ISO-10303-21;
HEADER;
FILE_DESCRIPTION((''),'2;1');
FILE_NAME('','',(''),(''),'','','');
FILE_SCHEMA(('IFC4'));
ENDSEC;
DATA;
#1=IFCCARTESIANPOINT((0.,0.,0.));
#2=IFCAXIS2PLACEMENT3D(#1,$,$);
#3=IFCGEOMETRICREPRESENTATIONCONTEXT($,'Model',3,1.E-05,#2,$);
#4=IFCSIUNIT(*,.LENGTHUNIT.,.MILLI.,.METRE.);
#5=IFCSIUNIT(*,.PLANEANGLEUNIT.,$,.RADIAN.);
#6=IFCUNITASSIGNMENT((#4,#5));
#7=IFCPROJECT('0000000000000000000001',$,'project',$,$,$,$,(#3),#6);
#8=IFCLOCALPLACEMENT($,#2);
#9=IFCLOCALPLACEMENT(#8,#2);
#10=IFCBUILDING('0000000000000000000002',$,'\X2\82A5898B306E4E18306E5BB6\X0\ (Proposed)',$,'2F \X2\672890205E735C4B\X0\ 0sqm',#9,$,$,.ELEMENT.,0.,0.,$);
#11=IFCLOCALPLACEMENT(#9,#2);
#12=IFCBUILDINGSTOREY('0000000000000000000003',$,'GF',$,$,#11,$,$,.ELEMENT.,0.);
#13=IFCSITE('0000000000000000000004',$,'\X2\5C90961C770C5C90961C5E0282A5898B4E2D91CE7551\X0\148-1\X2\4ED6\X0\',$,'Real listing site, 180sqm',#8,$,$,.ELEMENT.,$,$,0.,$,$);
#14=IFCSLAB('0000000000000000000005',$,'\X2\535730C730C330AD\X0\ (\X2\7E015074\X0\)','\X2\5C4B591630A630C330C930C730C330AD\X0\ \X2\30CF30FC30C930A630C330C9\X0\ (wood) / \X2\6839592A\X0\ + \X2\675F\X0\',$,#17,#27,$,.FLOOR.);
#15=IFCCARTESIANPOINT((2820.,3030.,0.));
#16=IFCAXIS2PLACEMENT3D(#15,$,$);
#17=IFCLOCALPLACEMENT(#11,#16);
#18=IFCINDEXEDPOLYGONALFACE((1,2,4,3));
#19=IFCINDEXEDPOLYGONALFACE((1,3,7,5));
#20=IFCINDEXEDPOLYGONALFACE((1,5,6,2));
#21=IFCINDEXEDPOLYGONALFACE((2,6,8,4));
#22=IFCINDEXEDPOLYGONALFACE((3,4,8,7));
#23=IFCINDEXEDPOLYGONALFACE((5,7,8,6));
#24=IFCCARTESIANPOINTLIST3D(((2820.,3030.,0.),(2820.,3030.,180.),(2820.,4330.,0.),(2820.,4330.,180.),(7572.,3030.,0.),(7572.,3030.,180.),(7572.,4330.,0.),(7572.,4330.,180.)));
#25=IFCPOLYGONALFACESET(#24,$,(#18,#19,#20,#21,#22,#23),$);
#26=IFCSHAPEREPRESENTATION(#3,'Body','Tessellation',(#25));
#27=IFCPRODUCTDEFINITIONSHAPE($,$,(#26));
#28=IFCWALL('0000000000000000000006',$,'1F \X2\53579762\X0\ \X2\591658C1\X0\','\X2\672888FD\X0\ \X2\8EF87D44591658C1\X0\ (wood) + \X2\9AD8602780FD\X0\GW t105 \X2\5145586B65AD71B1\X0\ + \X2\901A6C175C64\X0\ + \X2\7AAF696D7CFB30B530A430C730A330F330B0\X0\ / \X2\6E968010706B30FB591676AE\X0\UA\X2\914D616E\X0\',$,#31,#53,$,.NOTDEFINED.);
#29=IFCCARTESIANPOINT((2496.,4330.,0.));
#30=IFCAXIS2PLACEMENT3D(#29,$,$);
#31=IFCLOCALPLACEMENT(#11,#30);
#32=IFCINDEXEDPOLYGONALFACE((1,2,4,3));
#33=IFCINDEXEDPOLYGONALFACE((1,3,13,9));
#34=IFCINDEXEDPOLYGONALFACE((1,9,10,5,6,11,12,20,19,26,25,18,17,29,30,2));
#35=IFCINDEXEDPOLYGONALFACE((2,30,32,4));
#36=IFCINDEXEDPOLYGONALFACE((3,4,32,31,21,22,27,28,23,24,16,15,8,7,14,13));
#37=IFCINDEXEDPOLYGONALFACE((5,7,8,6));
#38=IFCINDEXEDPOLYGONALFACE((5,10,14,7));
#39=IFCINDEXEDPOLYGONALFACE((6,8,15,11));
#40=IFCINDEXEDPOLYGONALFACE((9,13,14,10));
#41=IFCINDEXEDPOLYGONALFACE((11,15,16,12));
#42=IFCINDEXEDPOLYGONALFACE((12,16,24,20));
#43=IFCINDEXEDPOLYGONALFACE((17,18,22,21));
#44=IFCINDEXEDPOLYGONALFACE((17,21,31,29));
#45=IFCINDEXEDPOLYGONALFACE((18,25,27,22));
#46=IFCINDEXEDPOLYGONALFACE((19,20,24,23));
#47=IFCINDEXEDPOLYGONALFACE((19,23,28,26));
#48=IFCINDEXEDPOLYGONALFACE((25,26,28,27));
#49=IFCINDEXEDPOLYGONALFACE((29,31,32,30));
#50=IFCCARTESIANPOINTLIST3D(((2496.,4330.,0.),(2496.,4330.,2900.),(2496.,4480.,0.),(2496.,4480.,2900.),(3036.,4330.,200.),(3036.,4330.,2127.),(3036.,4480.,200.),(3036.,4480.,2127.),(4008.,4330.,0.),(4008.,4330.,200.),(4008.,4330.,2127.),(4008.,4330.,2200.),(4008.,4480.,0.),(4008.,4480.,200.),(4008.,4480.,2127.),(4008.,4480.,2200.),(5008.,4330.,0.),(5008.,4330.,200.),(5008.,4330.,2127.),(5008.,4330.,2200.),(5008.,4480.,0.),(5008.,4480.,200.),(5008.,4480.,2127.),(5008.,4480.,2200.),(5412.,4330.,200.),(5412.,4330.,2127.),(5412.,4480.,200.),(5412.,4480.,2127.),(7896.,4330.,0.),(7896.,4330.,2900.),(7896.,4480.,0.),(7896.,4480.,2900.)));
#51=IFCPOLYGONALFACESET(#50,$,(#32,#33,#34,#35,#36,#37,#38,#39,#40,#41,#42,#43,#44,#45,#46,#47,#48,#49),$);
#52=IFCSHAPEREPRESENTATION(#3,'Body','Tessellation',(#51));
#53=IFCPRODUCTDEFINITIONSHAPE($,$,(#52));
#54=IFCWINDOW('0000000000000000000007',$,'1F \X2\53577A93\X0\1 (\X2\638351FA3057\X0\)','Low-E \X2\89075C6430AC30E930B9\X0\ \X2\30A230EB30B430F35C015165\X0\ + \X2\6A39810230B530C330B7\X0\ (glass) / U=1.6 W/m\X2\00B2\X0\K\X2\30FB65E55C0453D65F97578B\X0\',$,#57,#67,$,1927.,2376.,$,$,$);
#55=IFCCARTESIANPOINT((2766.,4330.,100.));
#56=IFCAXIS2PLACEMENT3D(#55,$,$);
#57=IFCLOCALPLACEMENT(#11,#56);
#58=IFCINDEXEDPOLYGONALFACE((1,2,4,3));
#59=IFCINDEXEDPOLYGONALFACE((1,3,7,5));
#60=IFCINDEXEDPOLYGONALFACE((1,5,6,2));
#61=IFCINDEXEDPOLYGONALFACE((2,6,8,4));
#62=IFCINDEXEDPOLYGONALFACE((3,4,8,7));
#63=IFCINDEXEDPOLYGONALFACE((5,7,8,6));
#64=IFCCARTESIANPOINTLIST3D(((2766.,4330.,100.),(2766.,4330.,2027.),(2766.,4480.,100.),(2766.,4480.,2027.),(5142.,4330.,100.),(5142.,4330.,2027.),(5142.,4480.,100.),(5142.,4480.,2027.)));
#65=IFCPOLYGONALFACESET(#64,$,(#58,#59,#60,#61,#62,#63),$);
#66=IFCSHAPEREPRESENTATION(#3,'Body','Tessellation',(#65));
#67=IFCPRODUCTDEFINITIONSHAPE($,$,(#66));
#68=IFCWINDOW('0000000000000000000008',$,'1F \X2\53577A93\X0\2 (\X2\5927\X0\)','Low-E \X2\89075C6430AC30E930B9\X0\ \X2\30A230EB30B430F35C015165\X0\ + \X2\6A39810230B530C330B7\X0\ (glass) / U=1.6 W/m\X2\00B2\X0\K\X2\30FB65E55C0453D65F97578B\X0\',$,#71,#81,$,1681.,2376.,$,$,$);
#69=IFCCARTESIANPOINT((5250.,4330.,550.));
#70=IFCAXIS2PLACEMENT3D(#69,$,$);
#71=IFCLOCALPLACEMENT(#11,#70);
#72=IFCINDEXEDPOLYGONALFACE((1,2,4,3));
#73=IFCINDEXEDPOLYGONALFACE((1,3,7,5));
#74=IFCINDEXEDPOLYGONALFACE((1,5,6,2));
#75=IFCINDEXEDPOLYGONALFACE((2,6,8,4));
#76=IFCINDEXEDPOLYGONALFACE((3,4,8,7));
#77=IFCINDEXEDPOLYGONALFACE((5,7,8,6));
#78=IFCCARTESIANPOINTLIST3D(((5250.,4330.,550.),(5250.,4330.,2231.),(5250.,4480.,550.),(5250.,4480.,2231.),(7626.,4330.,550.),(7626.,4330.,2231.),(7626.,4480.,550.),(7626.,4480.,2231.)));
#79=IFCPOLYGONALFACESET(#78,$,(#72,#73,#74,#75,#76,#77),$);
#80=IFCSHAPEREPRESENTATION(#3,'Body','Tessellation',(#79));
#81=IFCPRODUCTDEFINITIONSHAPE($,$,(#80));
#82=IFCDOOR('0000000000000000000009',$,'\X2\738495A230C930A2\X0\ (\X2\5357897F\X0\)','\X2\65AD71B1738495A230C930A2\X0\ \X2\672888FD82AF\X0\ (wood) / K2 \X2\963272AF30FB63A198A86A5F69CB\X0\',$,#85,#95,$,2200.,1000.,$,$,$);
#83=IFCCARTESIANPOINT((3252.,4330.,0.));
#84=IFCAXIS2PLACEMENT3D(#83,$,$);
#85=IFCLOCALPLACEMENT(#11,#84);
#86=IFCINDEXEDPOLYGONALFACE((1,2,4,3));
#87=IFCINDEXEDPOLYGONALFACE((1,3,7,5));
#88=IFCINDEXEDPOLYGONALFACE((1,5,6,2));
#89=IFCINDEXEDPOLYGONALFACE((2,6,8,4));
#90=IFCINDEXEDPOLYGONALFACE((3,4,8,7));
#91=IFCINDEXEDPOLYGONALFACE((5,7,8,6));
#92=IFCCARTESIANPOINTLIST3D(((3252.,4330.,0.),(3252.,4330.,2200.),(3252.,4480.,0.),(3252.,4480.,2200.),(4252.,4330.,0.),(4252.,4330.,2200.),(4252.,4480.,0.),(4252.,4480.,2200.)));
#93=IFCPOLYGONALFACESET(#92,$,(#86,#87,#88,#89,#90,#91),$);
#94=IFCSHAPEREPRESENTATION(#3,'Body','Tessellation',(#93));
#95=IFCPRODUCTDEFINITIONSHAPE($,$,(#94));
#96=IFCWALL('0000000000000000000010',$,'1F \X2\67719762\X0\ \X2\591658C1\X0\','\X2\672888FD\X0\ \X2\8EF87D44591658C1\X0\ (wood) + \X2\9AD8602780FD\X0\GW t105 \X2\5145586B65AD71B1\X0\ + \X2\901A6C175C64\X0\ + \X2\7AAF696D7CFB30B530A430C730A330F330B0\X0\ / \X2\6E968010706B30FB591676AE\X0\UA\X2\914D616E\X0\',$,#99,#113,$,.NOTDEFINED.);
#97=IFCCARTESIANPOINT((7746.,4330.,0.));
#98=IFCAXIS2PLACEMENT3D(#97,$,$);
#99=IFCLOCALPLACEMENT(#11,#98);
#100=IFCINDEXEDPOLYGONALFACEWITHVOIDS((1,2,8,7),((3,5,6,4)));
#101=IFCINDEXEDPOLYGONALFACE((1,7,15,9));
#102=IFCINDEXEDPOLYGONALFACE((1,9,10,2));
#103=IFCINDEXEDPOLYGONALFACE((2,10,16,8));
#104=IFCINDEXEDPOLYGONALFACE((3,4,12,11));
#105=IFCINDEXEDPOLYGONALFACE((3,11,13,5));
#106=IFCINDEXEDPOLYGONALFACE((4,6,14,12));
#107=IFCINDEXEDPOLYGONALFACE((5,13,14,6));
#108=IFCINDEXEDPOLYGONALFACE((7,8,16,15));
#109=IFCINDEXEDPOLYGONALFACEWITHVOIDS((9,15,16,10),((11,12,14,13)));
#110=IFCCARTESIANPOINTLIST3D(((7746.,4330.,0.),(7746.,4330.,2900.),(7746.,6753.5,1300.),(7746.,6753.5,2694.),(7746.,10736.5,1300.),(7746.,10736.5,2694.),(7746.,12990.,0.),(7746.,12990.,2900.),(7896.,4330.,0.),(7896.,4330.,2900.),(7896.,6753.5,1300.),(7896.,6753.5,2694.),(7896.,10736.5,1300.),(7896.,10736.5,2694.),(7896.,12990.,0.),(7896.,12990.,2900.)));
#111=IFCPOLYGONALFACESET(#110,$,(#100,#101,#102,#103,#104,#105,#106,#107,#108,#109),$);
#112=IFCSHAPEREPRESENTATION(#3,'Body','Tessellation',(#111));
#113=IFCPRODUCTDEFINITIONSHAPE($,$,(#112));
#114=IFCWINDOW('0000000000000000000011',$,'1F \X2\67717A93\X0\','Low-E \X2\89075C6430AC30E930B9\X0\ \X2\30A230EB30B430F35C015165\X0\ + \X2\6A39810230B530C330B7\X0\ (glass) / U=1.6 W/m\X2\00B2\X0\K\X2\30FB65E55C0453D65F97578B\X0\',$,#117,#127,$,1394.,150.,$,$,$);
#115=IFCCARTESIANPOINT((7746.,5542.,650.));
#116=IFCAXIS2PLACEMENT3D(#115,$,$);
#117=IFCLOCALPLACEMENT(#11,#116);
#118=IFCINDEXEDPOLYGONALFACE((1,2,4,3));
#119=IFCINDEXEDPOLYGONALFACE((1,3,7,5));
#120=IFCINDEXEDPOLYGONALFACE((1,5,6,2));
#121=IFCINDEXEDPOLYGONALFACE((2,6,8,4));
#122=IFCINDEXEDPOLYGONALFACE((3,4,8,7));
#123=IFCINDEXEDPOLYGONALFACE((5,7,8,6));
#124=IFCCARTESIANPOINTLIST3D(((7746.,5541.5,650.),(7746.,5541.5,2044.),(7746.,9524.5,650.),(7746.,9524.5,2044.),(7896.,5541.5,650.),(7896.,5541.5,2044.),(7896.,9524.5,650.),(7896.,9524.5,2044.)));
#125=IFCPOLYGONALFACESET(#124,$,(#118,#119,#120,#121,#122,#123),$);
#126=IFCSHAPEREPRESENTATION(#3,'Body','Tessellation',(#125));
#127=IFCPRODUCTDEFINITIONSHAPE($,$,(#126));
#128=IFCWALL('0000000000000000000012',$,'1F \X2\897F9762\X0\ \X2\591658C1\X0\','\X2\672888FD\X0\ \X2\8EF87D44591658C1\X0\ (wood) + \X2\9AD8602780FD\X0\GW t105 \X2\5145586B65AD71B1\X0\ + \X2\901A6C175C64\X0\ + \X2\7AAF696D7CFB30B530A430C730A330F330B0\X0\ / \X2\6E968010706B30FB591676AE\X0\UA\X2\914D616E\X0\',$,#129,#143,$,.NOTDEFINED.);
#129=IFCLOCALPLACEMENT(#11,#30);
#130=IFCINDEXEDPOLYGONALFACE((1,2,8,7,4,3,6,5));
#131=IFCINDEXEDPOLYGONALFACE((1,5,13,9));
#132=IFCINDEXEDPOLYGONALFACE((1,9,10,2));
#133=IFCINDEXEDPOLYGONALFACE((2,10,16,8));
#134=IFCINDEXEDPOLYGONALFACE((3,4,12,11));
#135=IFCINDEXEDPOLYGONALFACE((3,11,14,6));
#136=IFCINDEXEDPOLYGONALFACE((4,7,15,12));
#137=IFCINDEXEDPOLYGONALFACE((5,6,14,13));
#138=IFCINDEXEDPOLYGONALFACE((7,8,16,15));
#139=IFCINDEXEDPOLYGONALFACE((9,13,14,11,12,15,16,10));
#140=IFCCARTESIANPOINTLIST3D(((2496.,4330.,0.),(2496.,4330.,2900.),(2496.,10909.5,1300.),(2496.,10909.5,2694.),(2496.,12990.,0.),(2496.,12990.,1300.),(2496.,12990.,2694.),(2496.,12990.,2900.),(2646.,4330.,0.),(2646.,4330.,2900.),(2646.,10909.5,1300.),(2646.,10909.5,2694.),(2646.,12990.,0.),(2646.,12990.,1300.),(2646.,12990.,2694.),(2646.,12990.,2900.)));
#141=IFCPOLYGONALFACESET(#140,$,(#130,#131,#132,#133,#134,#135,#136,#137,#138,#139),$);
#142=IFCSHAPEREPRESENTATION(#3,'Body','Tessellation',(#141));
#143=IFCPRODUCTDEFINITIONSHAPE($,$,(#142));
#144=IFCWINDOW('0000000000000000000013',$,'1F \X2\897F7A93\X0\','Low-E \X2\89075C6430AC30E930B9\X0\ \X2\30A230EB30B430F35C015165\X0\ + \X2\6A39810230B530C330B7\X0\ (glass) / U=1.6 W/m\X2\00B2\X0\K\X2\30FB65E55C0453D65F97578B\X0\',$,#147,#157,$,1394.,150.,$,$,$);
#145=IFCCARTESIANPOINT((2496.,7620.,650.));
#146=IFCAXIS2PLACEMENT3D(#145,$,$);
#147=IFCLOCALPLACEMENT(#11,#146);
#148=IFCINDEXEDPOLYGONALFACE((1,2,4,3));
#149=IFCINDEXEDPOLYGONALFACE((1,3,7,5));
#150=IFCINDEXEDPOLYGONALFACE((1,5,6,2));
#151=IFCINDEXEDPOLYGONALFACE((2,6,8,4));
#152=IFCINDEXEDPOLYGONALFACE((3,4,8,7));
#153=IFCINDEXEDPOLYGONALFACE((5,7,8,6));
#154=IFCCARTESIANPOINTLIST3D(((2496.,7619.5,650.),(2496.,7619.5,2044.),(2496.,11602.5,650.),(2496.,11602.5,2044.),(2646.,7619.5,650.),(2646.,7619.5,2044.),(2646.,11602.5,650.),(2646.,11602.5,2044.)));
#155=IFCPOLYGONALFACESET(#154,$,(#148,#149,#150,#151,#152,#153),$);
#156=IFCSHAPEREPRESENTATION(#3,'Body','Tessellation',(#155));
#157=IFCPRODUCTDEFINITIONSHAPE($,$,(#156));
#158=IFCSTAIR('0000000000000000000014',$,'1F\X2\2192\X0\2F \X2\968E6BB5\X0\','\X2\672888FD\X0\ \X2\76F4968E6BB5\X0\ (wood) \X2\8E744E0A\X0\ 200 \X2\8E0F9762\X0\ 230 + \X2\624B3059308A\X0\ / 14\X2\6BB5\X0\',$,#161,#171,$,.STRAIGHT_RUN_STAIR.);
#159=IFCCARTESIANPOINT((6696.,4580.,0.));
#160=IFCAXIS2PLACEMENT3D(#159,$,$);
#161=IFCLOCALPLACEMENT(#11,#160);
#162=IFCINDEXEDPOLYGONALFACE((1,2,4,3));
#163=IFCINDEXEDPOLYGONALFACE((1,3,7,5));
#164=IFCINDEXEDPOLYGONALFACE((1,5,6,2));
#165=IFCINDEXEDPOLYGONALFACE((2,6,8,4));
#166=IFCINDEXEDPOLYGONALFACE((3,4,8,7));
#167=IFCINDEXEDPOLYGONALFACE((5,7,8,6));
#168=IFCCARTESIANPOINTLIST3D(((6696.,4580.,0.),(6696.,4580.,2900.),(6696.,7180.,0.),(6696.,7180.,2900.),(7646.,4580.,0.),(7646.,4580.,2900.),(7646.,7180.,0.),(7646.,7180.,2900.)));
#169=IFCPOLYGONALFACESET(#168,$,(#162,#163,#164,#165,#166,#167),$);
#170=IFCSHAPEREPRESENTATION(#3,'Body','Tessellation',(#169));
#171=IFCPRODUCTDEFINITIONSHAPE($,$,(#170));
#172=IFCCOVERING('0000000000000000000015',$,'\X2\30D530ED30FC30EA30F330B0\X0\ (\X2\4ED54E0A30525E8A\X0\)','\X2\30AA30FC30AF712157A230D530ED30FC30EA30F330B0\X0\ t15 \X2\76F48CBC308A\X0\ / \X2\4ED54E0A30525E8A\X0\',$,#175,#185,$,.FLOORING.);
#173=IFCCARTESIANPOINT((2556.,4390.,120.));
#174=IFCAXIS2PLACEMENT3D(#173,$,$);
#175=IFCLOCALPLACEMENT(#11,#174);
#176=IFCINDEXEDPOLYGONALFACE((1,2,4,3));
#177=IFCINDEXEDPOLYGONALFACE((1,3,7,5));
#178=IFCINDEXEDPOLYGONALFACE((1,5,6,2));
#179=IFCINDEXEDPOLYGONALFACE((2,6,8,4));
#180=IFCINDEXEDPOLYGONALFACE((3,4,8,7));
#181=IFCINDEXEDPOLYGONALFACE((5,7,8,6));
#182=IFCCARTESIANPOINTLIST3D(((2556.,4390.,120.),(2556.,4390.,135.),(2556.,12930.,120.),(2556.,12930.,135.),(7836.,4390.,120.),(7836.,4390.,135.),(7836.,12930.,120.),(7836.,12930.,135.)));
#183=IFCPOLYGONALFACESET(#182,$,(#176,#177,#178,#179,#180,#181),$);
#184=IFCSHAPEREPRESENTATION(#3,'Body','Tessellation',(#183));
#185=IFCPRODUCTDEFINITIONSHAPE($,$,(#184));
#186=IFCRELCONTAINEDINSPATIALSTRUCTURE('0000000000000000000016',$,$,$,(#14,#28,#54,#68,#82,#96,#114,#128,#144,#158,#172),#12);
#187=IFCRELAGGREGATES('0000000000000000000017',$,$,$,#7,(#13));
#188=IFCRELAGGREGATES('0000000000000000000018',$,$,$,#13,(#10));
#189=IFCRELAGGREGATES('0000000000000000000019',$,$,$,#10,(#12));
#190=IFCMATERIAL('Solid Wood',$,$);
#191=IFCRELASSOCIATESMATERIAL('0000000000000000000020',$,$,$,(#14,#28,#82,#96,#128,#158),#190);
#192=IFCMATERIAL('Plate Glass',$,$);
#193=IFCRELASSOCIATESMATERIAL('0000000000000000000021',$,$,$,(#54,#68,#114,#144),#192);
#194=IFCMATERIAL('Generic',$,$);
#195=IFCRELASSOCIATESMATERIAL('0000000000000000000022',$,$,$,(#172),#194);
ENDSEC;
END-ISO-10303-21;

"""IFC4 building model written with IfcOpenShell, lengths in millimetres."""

from ifc_helpers import new_model, si_unit, frame, frame_2d, origin, place, context, project, spatial, rectangle, extrude, material, element, fill, save


model = new_model("IFC4")

# Units and contexts
model_context = context("Model", 3, precision=1e-05, world=origin())
ifc_project = project(units=[si_unit("LENGTHUNIT", "METRE", prefix="MILLI"), si_unit("PLANEANGLEUNIT", "RADIAN")], contexts=[model_context])

# Site, building, storey
site_placement = place(None, origin())
site = spatial("IfcSite", under=ifc_project, at=site_placement, Name="岐阜県岐阜市芥見中野畑148-1他", ObjectType="Real listing site, 180sqm", CompositionType="ELEMENT", RefElevation=0.0)
building_placement = place(site_placement, origin())
building = spatial("IfcBuilding", under=site, at=building_placement, Name="芥見の丘の家 (Proposed)", ObjectType="2F 木造平屋 0sqm", CompositionType="ELEMENT", ElevationOfRefHeight=0.0, ElevationOfTerrain=0.0)
storey_placement = place(building_placement, origin())
storey = spatial("IfcBuildingStorey", under=building, at=storey_placement, Name="GF", CompositionType="ELEMENT", Elevation=0.0)

# Slab
ifc_material_1 = material(Name="Solid Wood")
slab_1_placement = place(storey_placement, frame((2820.0, 3030.0, 0.0)))
element("IfcSlab", 1, at=slab_1_placement, inside=storey, material=ifc_material_1, Name="南デッキ (縁側)", Description="屋外ウッドデッキ ハードウッド (wood) / 根太 + 束", PredefinedType="FLOOR", context=model_context, shape_type="SweptSolid", body=[
    extrude(rectangle(XDim=4752.0, YDim=1300.0, at=frame_2d((2376.0, 650.0))), frame((2820.0, 3030.0, 0.0)), (0.0, 0.0, 1.0), 180.0),
])

# Wall, openings, windows, door
wall_1_placement = place(storey_placement, frame((2496.0, 4330.0, 0.0)))
wall_1 = element("IfcWall", 2, at=wall_1_placement, inside=storey, material=ifc_material_1, Name="1F 南面 外壁", Description="木製 軸組外壁 (wood) + 高性能GW t105 充填断熱 + 通気層 + 窯業系サイディング / 準耐火・外皮UA配慮", PredefinedType="NOTDEFINED", context=model_context, shape_type="SweptSolid", body=[
    extrude(rectangle(XDim=5400.0, YDim=150.0, at=frame_2d((2700.0, 75.0))), frame((2496.0, 4330.0, 0.0)), (0.0, 0.0, 1.0), 2900.0),
])
opening_1_placement = place(storey_placement, frame((2766.0, 4330.0, 100.0)))
opening_1 = element("IfcOpeningElement", 3, at=opening_1_placement, cuts=wall_1, PredefinedType="NOTDEFINED", context=model_context, shape_type="SweptSolid", body=[
    extrude(rectangle(XDim=2376.0, YDim=150.0, at=frame_2d((1188.0, 75.0))), frame((2766.0, 4330.0, 100.0)), (0.0, 0.0, 1.0), 1927.0),
])
opening_2_placement = place(storey_placement, frame((5250.0, 4330.0, 550.0)))
opening_2 = element("IfcOpeningElement", 4, at=opening_2_placement, cuts=wall_1, PredefinedType="NOTDEFINED", context=model_context, shape_type="SweptSolid", body=[
    extrude(rectangle(XDim=2376.0, YDim=150.0, at=frame_2d((1188.0, 75.0))), frame((5250.0, 4330.0, 550.0)), (0.0, 0.0, 1.0), 1681.0),
])
opening_3_placement = place(storey_placement, frame((3252.0, 4330.0, 0.0)))
opening_3 = element("IfcOpeningElement", 5, at=opening_3_placement, cuts=wall_1, PredefinedType="NOTDEFINED", context=model_context, shape_type="SweptSolid", body=[
    extrude(rectangle(XDim=1000.0, YDim=150.0, at=frame_2d((500.0, 75.0))), frame((3252.0, 4330.0, 0.0)), (0.0, 0.0, 1.0), 2200.0),
])
ifc_material_2 = material(Name="Plate Glass")
window_1_placement = place(storey_placement, frame((2766.0, 4330.0, 100.0)))
window_1 = element("IfcWindow", 6, at=window_1_placement, inside=storey, material=ifc_material_2, Name="1F 南窓1 (掃出し)", Description="Low-E 複層ガラス アルゴン封入 + 樹脂サッシ (glass) / U=1.6 W/m²K・日射取得型", OverallHeight=1927.0, OverallWidth=2376.0, context=model_context, shape_type="SweptSolid", body=[
    extrude(rectangle(XDim=2376.0, YDim=150.0, at=frame_2d((1188.0, 75.0))), frame((2766.0, 4330.0, 100.0)), (0.0, 0.0, 1.0), 1927.0),
])
fill(opening_1, window_1)
window_2_placement = place(storey_placement, frame((5250.0, 4330.0, 550.0)))
window_2 = element("IfcWindow", 7, at=window_2_placement, inside=storey, material=ifc_material_2, Name="1F 南窓2 (大)", Description="Low-E 複層ガラス アルゴン封入 + 樹脂サッシ (glass) / U=1.6 W/m²K・日射取得型", OverallHeight=1681.0, OverallWidth=2376.0, context=model_context, shape_type="SweptSolid", body=[
    extrude(rectangle(XDim=2376.0, YDim=150.0, at=frame_2d((1188.0, 75.0))), frame((5250.0, 4330.0, 550.0)), (0.0, 0.0, 1.0), 1681.0),
])
fill(opening_2, window_2)
door_placement = place(storey_placement, frame((3252.0, 4330.0, 0.0)))
door = element("IfcDoor", 8, at=door_placement, inside=storey, material=ifc_material_1, Name="玄関ドア (南西)", Description="断熱玄関ドア 木製芯 (wood) / K2 防犯・採風機構", OverallHeight=2200.0, OverallWidth=1000.0, context=model_context, shape_type="SweptSolid", body=[
    extrude(rectangle(XDim=1000.0, YDim=150.0, at=frame_2d((500.0, 75.0))), frame((3252.0, 4330.0, 0.0)), (0.0, 0.0, 1.0), 2200.0),
])
fill(opening_3, door)

# Walls, openings, windows
wall_2_placement = place(storey_placement, frame((7746.0, 4330.0, 0.0)))
wall_2 = element("IfcWall", 9, at=wall_2_placement, inside=storey, material=ifc_material_1, Name="1F 東面 外壁", Description="木製 軸組外壁 (wood) + 高性能GW t105 充填断熱 + 通気層 + 窯業系サイディング / 準耐火・外皮UA配慮", PredefinedType="NOTDEFINED", context=model_context, shape_type="SweptSolid", body=[
    extrude(rectangle(XDim=150.0, YDim=8660.0, at=frame_2d((75.0, 4330.0))), frame((7746.0, 4330.0, 0.0)), (0.0, 0.0, 1.0), 2900.0),
])
opening_4_placement = place(storey_placement, frame((7746.0, 5542.0, 650.0)))
opening_4 = element("IfcOpeningElement", 10, at=opening_4_placement, cuts=wall_2, PredefinedType="NOTDEFINED", context=model_context, shape_type="SweptSolid", body=[
    extrude(rectangle(XDim=150.0, YDim=3983.0, at=frame_2d((75.0, 1991.0))), frame((7746.0, 5542.0, 650.0)), (0.0, 0.0, 1.0), 1394.0),
])
window_3_placement = place(storey_placement, frame((7746.0, 5542.0, 650.0)))
window_3 = element("IfcWindow", 11, at=window_3_placement, inside=storey, material=ifc_material_2, Name="1F 東窓", Description="Low-E 複層ガラス アルゴン封入 + 樹脂サッシ (glass) / U=1.6 W/m²K・日射取得型", OverallHeight=1394.0, OverallWidth=150.0, context=model_context, shape_type="SweptSolid", body=[
    extrude(rectangle(XDim=150.0, YDim=3983.0, at=frame_2d((75.0, 1991.0))), frame((7746.0, 5542.0, 650.0)), (0.0, 0.0, 1.0), 1394.0),
])
fill(opening_4, window_3)
wall_3_placement = place(storey_placement, frame((2496.0, 4330.0, 0.0)))
wall_3 = element("IfcWall", 12, at=wall_3_placement, inside=storey, material=ifc_material_1, Name="1F 西面 外壁", Description="木製 軸組外壁 (wood) + 高性能GW t105 充填断熱 + 通気層 + 窯業系サイディング / 準耐火・外皮UA配慮", PredefinedType="NOTDEFINED", context=model_context, shape_type="SweptSolid", body=[
    extrude(rectangle(XDim=150.0, YDim=8660.0, at=frame_2d((75.0, 4330.0))), frame((2496.0, 4330.0, 0.0)), (0.0, 0.0, 1.0), 2900.0),
])
opening_5_placement = place(storey_placement, frame((2496.0, 7620.0, 650.0)))
opening_5 = element("IfcOpeningElement", 13, at=opening_5_placement, cuts=wall_3, PredefinedType="NOTDEFINED", context=model_context, shape_type="SweptSolid", body=[
    extrude(rectangle(XDim=150.0, YDim=3983.0, at=frame_2d((75.0, 1991.0))), frame((2496.0, 7620.0, 650.0)), (0.0, 0.0, 1.0), 1394.0),
])
window_4_placement = place(storey_placement, frame((2496.0, 7620.0, 650.0)))
window_4 = element("IfcWindow", 14, at=window_4_placement, inside=storey, material=ifc_material_2, Name="1F 西窓", Description="Low-E 複層ガラス アルゴン封入 + 樹脂サッシ (glass) / U=1.6 W/m²K・日射取得型", OverallHeight=1394.0, OverallWidth=150.0, context=model_context, shape_type="SweptSolid", body=[
    extrude(rectangle(XDim=150.0, YDim=3983.0, at=frame_2d((75.0, 1991.0))), frame((2496.0, 7620.0, 650.0)), (0.0, 0.0, 1.0), 1394.0),
])
fill(opening_5, window_4)

# Stair
stair_placement = place(storey_placement, frame((6696.0, 4580.0, 0.0)))
element("IfcStair", 15, at=stair_placement, inside=storey, material=ifc_material_1, Name="1F→2F 階段", Description="木製 直階段 (wood) 蹴上 200 踏面 230 + 手すり / 14段", PredefinedType="STRAIGHT_RUN_STAIR", context=model_context, shape_type="SweptSolid", body=[
    extrude(rectangle(XDim=950.0, YDim=2600.0, at=frame_2d((475.0, 1300.0))), frame((6696.0, 4580.0, 0.0)), (0.0, 0.0, 1.0), 2900.0),
])

# Covering
ifc_material_3 = material(Name="Generic")
covering_placement = place(storey_placement, frame((2556.0, 4390.0, 120.0)))
element("IfcCovering", 16, at=covering_placement, inside=storey, material=ifc_material_3, Name="フローリング (仕上げ床)", Description="オーク無垢フローリング t15 直貼り / 仕上げ床", PredefinedType="FLOORING", context=model_context, shape_type="SweptSolid", body=[
    extrude(rectangle(XDim=5280.0, YDim=8540.0, at=frame_2d((2640.0, 4270.0))), frame((2556.0, 4390.0, 120.0)), (0.0, 0.0, 1.0), 15.0),
])

save(model, "model.ifc")
